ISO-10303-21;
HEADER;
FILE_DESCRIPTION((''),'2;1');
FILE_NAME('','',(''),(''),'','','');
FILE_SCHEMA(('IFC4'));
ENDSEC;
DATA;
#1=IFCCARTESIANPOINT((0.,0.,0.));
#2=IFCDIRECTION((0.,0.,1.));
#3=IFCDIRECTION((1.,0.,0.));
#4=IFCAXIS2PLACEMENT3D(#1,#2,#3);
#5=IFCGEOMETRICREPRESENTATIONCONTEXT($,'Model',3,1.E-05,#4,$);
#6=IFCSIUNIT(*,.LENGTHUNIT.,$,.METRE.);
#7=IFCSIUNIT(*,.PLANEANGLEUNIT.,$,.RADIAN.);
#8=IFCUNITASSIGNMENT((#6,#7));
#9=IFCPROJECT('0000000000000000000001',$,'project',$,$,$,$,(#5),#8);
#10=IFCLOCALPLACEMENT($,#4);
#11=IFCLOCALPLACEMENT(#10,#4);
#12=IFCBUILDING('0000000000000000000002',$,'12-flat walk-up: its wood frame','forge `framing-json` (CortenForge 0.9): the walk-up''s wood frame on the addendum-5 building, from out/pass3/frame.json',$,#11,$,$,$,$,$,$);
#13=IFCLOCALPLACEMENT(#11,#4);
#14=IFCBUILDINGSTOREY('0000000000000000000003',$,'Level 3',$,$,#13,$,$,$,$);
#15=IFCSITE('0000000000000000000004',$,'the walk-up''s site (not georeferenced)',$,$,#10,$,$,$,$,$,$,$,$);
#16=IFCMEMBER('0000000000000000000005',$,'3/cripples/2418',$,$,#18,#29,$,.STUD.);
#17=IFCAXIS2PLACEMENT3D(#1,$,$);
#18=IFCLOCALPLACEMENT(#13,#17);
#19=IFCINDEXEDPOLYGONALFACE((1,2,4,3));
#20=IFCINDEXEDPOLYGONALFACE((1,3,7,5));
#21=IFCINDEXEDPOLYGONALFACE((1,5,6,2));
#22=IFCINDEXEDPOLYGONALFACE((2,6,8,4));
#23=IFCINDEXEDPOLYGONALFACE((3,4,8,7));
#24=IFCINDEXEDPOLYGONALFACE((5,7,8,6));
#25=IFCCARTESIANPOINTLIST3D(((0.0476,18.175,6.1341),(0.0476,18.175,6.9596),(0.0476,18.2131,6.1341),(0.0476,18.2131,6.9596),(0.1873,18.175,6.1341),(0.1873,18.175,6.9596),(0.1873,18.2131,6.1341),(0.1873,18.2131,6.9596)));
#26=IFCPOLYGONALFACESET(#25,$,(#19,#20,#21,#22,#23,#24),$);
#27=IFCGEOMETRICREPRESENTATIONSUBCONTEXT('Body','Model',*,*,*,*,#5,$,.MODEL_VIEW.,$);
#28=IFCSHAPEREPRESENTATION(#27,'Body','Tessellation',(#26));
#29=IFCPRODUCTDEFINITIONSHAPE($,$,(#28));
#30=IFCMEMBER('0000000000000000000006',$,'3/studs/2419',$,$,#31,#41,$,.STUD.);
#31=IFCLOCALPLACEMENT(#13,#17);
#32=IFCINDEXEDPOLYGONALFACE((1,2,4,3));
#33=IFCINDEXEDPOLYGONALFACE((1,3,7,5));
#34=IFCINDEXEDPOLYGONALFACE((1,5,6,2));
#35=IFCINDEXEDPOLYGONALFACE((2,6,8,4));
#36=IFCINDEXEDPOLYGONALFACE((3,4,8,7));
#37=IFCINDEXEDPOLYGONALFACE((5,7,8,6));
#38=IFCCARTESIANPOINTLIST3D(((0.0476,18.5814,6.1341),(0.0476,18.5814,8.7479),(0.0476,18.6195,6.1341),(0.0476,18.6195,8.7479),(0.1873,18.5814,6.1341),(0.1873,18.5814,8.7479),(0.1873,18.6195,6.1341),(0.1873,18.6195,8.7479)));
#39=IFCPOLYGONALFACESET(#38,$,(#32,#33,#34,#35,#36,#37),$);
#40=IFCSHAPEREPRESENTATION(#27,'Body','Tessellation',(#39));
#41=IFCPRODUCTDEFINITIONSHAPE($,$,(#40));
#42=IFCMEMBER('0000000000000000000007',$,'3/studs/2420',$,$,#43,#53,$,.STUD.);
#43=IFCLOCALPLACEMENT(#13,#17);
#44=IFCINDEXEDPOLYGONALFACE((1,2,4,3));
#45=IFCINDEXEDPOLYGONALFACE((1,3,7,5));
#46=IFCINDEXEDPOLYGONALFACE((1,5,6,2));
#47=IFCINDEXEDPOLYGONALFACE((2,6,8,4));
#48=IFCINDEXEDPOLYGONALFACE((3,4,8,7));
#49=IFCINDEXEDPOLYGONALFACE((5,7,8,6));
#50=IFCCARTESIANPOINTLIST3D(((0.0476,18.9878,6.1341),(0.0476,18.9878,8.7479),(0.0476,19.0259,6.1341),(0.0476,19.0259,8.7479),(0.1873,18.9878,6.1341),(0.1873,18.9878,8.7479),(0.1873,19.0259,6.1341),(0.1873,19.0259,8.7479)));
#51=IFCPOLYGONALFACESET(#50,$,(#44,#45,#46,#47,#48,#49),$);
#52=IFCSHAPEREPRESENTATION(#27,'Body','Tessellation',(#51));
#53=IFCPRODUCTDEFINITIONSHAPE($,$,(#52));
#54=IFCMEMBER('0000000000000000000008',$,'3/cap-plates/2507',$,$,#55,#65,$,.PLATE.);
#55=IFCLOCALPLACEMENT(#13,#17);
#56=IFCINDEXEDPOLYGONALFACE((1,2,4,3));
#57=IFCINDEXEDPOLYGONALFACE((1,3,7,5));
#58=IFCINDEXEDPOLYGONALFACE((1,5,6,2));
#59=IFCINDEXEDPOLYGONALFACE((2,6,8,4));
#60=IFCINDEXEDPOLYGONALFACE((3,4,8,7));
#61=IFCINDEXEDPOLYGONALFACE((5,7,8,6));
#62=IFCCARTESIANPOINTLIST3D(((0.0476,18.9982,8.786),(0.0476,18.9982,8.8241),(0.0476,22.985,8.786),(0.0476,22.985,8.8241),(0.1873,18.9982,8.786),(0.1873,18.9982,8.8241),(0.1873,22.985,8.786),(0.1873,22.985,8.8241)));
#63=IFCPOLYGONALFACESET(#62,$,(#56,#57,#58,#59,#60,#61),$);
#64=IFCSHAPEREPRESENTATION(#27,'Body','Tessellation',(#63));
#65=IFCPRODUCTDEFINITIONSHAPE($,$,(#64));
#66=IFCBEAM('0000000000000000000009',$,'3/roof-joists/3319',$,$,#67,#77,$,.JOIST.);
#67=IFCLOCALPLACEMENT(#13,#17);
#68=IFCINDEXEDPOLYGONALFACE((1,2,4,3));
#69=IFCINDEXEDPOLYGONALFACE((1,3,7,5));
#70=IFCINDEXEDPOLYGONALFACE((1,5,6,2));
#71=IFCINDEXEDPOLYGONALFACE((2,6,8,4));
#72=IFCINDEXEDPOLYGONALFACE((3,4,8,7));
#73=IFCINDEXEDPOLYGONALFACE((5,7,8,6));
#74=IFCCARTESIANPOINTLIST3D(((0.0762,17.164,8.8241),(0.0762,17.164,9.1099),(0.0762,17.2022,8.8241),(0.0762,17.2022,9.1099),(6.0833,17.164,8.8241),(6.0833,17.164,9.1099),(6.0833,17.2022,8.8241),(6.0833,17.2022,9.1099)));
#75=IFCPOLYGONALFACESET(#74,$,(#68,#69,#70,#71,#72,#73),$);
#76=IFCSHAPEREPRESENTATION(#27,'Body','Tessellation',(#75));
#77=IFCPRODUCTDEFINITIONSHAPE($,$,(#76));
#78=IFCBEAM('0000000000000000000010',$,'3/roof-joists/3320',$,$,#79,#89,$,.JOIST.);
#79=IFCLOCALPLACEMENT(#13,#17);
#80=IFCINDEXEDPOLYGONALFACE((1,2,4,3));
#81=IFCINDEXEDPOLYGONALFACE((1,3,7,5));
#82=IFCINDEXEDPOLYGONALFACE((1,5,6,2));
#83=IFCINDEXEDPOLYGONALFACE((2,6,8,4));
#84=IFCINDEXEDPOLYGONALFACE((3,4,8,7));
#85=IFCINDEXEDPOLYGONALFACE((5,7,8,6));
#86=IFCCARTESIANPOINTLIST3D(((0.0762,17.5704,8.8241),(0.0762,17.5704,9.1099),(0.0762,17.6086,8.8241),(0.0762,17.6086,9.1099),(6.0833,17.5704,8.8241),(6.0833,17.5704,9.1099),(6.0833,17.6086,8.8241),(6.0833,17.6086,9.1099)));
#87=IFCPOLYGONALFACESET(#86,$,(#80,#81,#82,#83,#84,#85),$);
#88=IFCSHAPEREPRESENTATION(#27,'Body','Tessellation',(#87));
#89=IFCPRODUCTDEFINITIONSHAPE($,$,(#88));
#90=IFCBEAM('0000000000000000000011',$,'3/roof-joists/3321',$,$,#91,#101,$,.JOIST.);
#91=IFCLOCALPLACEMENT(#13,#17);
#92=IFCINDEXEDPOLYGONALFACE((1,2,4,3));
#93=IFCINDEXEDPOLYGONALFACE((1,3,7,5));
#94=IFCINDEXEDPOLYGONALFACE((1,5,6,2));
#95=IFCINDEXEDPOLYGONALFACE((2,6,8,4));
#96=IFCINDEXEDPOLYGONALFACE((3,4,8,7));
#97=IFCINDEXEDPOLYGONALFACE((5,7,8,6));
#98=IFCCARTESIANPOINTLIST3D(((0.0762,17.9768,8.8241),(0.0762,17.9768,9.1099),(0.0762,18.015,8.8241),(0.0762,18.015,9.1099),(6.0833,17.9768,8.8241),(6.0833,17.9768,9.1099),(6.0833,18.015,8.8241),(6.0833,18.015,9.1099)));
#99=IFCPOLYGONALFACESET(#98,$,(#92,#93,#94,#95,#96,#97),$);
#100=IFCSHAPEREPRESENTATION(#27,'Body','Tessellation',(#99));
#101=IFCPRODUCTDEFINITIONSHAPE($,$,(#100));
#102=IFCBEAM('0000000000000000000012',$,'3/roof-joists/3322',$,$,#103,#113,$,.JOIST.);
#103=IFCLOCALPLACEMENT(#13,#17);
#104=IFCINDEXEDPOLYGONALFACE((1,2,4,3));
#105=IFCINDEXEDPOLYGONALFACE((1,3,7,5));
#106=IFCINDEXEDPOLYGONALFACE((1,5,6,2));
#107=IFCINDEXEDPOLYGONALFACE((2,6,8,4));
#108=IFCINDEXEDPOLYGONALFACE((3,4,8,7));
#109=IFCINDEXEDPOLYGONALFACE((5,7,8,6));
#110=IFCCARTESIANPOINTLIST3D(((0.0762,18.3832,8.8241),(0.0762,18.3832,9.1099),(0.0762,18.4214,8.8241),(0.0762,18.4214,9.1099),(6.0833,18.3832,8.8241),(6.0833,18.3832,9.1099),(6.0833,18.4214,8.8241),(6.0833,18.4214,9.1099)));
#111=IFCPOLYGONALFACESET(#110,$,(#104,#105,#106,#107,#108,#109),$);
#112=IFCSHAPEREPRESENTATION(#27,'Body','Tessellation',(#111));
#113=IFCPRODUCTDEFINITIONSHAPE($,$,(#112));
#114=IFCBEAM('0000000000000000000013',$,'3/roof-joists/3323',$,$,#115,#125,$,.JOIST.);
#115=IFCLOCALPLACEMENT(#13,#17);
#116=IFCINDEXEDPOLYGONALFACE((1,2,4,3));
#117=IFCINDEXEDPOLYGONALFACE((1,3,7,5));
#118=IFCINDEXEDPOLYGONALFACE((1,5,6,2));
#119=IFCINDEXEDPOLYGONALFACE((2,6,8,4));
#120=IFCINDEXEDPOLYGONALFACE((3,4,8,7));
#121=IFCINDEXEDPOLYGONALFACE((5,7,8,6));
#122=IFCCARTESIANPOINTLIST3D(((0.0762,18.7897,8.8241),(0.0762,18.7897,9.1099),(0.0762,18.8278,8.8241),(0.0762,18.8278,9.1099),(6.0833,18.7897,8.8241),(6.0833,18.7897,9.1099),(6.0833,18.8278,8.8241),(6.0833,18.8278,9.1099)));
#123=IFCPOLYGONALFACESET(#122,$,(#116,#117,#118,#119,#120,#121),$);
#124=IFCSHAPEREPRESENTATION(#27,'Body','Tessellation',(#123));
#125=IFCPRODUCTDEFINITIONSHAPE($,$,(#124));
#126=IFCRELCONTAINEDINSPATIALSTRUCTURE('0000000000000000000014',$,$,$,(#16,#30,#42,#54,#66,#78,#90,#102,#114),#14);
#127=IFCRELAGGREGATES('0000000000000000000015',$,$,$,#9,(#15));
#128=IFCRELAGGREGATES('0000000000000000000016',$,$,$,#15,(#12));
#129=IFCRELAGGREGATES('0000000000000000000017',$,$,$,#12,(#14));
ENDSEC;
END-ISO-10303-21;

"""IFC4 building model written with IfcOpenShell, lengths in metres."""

from ifc_helpers import new_model, si_unit, frame, frame_2d, origin, origin_with_axes, place, context, subcontext, project, spatial, rectangle, extrude, element, save


model = new_model("IFC4")

# Units and contexts
model_context = context("Model", 3, precision=1e-05, world=origin_with_axes())
body_context = subcontext(model_context, "Body", "Model", "MODEL_VIEW")
ifc_project = project(units=[si_unit("LENGTHUNIT", "METRE"), si_unit("PLANEANGLEUNIT", "RADIAN")], contexts=[model_context])

# Site, building, storey
site_placement = place(None, origin_with_axes())
site = spatial("IfcSite", under=ifc_project, at=site_placement, Name="the walk-up's site (not georeferenced)")
building_placement = place(site_placement, origin_with_axes())
building = spatial("IfcBuilding", under=site, at=building_placement, Name="12-flat walk-up: its wood frame", Description="forge `framing-json` (CortenForge 0.9): the walk-up's wood frame on the addendum-5 building, from out/pass3/frame.json")
storey_placement = place(building_placement, origin_with_axes())
storey = spatial("IfcBuildingStorey", under=building, at=storey_placement, Name="Level 3")

# Members
member_1_placement = place(storey_placement, frame((0.0476, 18.175, 6.1341), z_axis=(0.0, 0.0, 1.0), x_axis=(1.0, 0.0, 0.0)))
element("IfcMember", 1, at=member_1_placement, inside=storey, Name="3/cripples/2418", PredefinedType="STUD", context=body_context, shape_type="SweptSolid", body=[
    extrude(rectangle(XDim=0.1397, YDim=0.0381, at=frame_2d((0.0698, 0.0191))), origin(), (0.0, 0.0, 1.0), 0.8255),
])
for number, where, z_axis, x_axis, name in (
    (2, (0.0476, 18.5814, 6.1341), (0.0, 0.0, 1.0), (1.0, 0.0, 0.0), "3/studs/2419"),
    (3, (0.0476, 18.9878, 6.1341), (0.0, 0.0, 1.0), (1.0, 0.0, 0.0), "3/studs/2420"),
):
    element("IfcMember", number, at=place(storey_placement, frame(where, z_axis=z_axis, x_axis=x_axis)), inside=storey, Name=name, PredefinedType="STUD", context=body_context, shape_type="SweptSolid", body=[
        extrude(rectangle(XDim=0.1397, YDim=0.0381, at=frame_2d((0.0698, 0.0191))), origin(), (0.0, 0.0, 1.0), 2.6138),
    ])
member_2_placement = place(storey_placement, frame((0.0476, 18.9982, 8.786), z_axis=(0.0, 0.0, 1.0), x_axis=(1.0, 0.0, 0.0)))
element("IfcMember", 4, at=member_2_placement, inside=storey, Name="3/cap-plates/2507", PredefinedType="PLATE", context=body_context, shape_type="SweptSolid", body=[
    extrude(rectangle(XDim=0.1397, YDim=3.9868, at=frame_2d((0.0698, 1.9934))), origin(), (0.0, 0.0, 1.0), 0.0381),
])

# Beams
for number, where, z_axis, x_axis, name in (
    (5, (0.0762, 17.164, 8.8241), (0.0, 0.0, 1.0), (1.0, 0.0, 0.0), "3/roof-joists/3319"),
    (6, (0.0762, 17.5705, 8.8241), (0.0, 0.0, 1.0), (1.0, 0.0, 0.0), "3/roof-joists/3320"),
    (7, (0.0762, 17.9768, 8.8241), (0.0, 0.0, 1.0), (1.0, 0.0, 0.0), "3/roof-joists/3321"),
    (8, (0.0762, 18.3833, 8.8241), (0.0, 0.0, 1.0), (1.0, 0.0, 0.0), "3/roof-joists/3322"),
    (9, (0.0762, 18.7897, 8.8241), (0.0, 0.0, 1.0), (1.0, 0.0, 0.0), "3/roof-joists/3323"),
):
    element("IfcBeam", number, at=place(storey_placement, frame(where, z_axis=z_axis, x_axis=x_axis)), inside=storey, Name=name, PredefinedType="JOIST", context=body_context, shape_type="SweptSolid", body=[
        extrude(rectangle(XDim=6.0071, YDim=0.0381, at=frame_2d((3.0036, 0.0191))), origin(), (0.0, 0.0, 1.0), 0.2858),
    ])

save(model, "model.ifc")
